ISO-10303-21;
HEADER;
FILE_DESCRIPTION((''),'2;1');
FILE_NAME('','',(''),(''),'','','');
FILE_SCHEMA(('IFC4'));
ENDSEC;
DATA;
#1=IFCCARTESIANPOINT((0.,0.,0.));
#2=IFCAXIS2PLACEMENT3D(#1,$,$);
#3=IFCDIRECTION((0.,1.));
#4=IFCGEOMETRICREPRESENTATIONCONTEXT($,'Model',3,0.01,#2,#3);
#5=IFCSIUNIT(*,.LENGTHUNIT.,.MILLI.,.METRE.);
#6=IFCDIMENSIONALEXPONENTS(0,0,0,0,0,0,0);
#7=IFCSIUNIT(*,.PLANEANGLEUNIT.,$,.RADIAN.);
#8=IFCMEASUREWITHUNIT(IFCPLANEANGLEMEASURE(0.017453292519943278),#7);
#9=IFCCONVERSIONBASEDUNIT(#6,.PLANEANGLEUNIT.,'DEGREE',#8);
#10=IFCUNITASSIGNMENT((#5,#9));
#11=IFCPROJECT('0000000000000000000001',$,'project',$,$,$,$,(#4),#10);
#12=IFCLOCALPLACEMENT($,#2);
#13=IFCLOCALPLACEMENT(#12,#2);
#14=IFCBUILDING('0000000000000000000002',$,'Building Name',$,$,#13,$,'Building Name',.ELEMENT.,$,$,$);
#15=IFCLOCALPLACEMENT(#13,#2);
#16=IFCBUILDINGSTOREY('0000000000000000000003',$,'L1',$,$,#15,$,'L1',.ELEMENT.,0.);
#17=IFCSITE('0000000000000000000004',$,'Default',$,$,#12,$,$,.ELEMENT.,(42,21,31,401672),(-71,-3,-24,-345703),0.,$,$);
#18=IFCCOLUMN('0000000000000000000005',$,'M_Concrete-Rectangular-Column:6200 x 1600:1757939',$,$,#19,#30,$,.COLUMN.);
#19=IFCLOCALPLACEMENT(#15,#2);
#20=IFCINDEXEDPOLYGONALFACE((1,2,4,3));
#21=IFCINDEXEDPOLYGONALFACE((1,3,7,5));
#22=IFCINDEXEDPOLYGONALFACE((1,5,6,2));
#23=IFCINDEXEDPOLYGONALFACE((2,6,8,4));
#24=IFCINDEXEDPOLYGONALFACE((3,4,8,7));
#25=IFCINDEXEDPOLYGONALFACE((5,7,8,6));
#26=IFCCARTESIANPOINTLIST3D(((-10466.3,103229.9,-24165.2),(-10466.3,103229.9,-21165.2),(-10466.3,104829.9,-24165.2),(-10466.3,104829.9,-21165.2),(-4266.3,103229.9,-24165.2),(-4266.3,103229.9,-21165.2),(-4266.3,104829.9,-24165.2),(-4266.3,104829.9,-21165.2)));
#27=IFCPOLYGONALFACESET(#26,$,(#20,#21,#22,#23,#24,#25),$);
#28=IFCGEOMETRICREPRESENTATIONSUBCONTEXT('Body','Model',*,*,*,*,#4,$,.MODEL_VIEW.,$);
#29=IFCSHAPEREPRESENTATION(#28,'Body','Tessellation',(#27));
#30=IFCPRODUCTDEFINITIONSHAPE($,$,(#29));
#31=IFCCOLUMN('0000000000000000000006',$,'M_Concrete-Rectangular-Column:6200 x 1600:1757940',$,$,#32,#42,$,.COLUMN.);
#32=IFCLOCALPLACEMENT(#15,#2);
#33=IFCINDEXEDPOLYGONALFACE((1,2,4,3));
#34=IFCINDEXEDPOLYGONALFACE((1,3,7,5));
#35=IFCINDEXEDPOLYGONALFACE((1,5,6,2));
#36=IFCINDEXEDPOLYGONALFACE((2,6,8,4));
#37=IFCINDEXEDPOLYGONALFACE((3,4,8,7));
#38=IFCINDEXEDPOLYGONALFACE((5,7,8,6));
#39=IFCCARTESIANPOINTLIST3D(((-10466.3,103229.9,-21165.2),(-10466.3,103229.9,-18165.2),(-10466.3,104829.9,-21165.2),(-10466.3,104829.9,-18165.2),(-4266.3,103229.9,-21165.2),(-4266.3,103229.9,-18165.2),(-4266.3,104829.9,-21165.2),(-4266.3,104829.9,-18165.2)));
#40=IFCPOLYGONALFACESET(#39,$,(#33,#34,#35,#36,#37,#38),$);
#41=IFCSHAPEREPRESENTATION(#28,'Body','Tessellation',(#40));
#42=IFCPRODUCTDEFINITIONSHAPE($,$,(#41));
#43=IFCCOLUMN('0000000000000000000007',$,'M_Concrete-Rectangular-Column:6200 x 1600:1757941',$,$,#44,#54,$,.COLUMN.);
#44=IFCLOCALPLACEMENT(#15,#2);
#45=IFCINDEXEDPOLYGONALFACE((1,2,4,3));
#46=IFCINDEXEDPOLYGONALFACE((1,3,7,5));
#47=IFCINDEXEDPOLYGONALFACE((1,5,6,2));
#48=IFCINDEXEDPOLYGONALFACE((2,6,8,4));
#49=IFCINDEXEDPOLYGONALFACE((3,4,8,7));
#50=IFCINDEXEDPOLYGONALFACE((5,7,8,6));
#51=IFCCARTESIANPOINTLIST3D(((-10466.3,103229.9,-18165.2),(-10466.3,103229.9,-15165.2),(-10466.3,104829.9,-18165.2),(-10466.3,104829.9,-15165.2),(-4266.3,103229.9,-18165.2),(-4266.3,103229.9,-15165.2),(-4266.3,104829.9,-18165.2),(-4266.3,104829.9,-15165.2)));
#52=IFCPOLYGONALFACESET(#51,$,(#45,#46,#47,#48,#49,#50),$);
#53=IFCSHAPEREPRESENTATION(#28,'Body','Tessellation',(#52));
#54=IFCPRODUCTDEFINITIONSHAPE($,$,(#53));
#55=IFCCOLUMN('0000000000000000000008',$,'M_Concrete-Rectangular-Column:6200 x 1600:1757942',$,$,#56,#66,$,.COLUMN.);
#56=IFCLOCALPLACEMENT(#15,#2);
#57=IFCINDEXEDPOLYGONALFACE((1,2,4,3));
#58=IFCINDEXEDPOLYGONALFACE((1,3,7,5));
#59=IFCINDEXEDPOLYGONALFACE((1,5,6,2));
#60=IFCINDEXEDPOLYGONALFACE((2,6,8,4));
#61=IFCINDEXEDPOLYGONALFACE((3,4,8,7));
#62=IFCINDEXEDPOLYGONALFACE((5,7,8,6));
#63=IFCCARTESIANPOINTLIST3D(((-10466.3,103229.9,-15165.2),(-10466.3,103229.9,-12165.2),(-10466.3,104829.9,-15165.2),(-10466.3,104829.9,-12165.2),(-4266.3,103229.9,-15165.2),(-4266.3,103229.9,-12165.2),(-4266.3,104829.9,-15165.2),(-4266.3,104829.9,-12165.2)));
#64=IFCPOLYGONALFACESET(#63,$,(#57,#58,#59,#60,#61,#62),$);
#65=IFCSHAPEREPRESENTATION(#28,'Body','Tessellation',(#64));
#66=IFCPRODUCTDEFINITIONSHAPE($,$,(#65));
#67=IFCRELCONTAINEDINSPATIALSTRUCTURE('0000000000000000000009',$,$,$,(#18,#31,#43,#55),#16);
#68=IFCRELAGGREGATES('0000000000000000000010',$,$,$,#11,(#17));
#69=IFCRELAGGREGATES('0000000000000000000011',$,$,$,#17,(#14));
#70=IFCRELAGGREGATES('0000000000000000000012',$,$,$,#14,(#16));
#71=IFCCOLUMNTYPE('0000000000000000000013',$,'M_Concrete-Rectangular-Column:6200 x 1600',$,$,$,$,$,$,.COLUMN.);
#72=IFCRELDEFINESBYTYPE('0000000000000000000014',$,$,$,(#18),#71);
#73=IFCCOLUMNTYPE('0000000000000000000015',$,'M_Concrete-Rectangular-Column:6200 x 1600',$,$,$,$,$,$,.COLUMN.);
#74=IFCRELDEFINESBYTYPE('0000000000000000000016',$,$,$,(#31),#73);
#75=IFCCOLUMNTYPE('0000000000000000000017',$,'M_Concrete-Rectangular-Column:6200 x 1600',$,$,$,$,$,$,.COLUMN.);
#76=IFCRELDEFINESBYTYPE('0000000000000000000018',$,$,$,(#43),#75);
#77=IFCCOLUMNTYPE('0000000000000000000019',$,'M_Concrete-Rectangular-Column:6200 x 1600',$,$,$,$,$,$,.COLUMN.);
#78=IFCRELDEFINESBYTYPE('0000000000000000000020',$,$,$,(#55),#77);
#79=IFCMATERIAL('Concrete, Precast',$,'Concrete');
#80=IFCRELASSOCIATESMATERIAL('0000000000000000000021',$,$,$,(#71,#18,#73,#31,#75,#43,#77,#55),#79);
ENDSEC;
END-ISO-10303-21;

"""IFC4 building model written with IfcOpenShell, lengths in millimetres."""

from ifc_helpers import new_model, entity, si_unit, converted_unit, direction, frame, origin, place, context, subcontext, project, spatial, indexed_curve, outline, extrude, source, transform, mapped, material, type_object, type_shapes, element, save


model = new_model("IFC4")

# Units and contexts
model_context = context("Model", 3, precision=0.01, world=origin(), true_north=direction((0.0, 1.0)))
body_context = subcontext(model_context, "Body", "Model", "MODEL_VIEW")
ifc_project = project(units=[si_unit("LENGTHUNIT", "METRE", prefix="MILLI"), converted_unit("PLANEANGLEUNIT", "DEGREE", entity("IfcPlaneAngleMeasure", 0.017453292519943278), si_unit("PLANEANGLEUNIT", "RADIAN"), dimensions=[0, 0, 0, 0, 0, 0, 0])], contexts=[model_context])

# Site, building, storey
site_placement = place(None, origin())
site = spatial("IfcSite", under=ifc_project, at=site_placement, Name="Default", CompositionType="ELEMENT", RefLatitude=(42, 21, 31, 401672), RefLongitude=(-71, -3, -24, -345703), RefElevation=0.0)
building_placement = place(site_placement, origin())
building = spatial("IfcBuilding", under=site, at=building_placement, Name="Building Name", LongName="Building Name", CompositionType="ELEMENT")
storey_placement = place(building_placement, origin())
storey = spatial("IfcBuildingStorey", under=building, at=storey_placement, Name="L1", LongName="L1", CompositionType="ELEMENT", Elevation=0.0)

# Columns
ifc_material_1 = material(Name="Concrete, Precast", Category="Concrete")
column_type_1 = type_object("IfcColumnType", Name="M_Concrete-Rectangular-Column:6200 x 1600", PredefinedType="COLUMN", material=ifc_material_1)
shared_shape_1 = source(origin(), body_context, "Body", "SweptSolid", [
    extrude(outline(indexed_curve([(-800.0, -3100.0), (800.0, -3100.0), (800.0, 3100.0), (-800.0, 3100.0), (-800.0, -3100.0)], self_intersect=False)), frame((-7366.3, 104029.9, -24165.2), z_axis=(0.0, 0.0, 1.0), x_axis=(0.0, -1.0, 0.0)), (0.0, 0.0, 1.0), 3000.0),
])
type_shapes(column_type_1, [shared_shape_1])
column_1_placement = place(storey_placement, origin())
element("IfcColumn", 1, at=column_1_placement, inside=storey, type_object=column_type_1, material=ifc_material_1, Name="M_Concrete-Rectangular-Column:6200 x 1600:1757939", PredefinedType="COLUMN", context=body_context, shape_type="MappedRepresentation", body=[
    mapped(shared_shape_1, transform((0.0, 0.0, 0.0), scale=1.0)),
])
column_type_2 = type_object("IfcColumnType", Name="M_Concrete-Rectangular-Column:6200 x 1600", PredefinedType="COLUMN", material=ifc_material_1)
shared_shape_2 = source(origin(), body_context, "Body", "SweptSolid", [
    extrude(outline(indexed_curve([(-800.0, -3100.0), (800.0, -3100.0), (800.0, 3100.0), (-800.0, 3100.0), (-800.0, -3100.0)], self_intersect=False)), frame((-7366.3, 104029.9, -21165.2), z_axis=(0.0, 0.0, 1.0), x_axis=(0.0, -1.0, 0.0)), (0.0, 0.0, 1.0), 3000.0),
])
type_shapes(column_type_2, [shared_shape_2])
column_2_placement = place(storey_placement, origin())
element("IfcColumn", 2, at=column_2_placement, inside=storey, type_object=column_type_2, material=ifc_material_1, Name="M_Concrete-Rectangular-Column:6200 x 1600:1757940", PredefinedType="COLUMN", context=body_context, shape_type="MappedRepresentation", body=[
    mapped(shared_shape_2, transform((0.0, 0.0, 0.0), scale=1.0)),
])
column_type_3 = type_object("IfcColumnType", Name="M_Concrete-Rectangular-Column:6200 x 1600", PredefinedType="COLUMN", material=ifc_material_1)
shared_shape_3 = source(origin(), body_context, "Body", "SweptSolid", [
    extrude(outline(indexed_curve([(-800.0, -3100.0), (800.0, -3100.0), (800.0, 3100.0), (-800.0, 3100.0), (-800.0, -3100.0)], self_intersect=False)), frame((-7366.3, 104029.9, -18165.2), z_axis=(0.0, 0.0, 1.0), x_axis=(0.0, -1.0, 0.0)), (0.0, 0.0, 1.0), 3000.0),
])
type_shapes(column_type_3, [shared_shape_3])
column_3_placement = place(storey_placement, origin())
element("IfcColumn", 3, at=column_3_placement, inside=storey, type_object=column_type_3, material=ifc_material_1, Name="M_Concrete-Rectangular-Column:6200 x 1600:1757941", PredefinedType="COLUMN", context=body_context, shape_type="MappedRepresentation", body=[
    mapped(shared_shape_3, transform((0.0, 0.0, 0.0), scale=1.0)),
])
column_type_4 = type_object("IfcColumnType", Name="M_Concrete-Rectangular-Column:6200 x 1600", PredefinedType="COLUMN", material=ifc_material_1)
shared_shape_4 = source(origin(), body_context, "Body", "SweptSolid", [
    extrude(outline(indexed_curve([(-800.0, -3100.0), (800.0, -3100.0), (800.0, 3100.0), (-800.0, 3100.0), (-800.0, -3100.0)], self_intersect=False)), frame((-7366.3, 104029.9, -15165.2), z_axis=(0.0, 0.0, 1.0), x_axis=(0.0, -1.0, 0.0)), (0.0, 0.0, 1.0), 3000.0),
])
type_shapes(column_type_4, [shared_shape_4])
column_4_placement = place(storey_placement, origin())
element("IfcColumn", 4, at=column_4_placement, inside=storey, type_object=column_type_4, material=ifc_material_1, Name="M_Concrete-Rectangular-Column:6200 x 1600:1757942", PredefinedType="COLUMN", context=body_context, shape_type="MappedRepresentation", body=[
    mapped(shared_shape_4, transform((0.0, 0.0, 0.0), scale=1.0)),
])

save(model, "model.ifc")
